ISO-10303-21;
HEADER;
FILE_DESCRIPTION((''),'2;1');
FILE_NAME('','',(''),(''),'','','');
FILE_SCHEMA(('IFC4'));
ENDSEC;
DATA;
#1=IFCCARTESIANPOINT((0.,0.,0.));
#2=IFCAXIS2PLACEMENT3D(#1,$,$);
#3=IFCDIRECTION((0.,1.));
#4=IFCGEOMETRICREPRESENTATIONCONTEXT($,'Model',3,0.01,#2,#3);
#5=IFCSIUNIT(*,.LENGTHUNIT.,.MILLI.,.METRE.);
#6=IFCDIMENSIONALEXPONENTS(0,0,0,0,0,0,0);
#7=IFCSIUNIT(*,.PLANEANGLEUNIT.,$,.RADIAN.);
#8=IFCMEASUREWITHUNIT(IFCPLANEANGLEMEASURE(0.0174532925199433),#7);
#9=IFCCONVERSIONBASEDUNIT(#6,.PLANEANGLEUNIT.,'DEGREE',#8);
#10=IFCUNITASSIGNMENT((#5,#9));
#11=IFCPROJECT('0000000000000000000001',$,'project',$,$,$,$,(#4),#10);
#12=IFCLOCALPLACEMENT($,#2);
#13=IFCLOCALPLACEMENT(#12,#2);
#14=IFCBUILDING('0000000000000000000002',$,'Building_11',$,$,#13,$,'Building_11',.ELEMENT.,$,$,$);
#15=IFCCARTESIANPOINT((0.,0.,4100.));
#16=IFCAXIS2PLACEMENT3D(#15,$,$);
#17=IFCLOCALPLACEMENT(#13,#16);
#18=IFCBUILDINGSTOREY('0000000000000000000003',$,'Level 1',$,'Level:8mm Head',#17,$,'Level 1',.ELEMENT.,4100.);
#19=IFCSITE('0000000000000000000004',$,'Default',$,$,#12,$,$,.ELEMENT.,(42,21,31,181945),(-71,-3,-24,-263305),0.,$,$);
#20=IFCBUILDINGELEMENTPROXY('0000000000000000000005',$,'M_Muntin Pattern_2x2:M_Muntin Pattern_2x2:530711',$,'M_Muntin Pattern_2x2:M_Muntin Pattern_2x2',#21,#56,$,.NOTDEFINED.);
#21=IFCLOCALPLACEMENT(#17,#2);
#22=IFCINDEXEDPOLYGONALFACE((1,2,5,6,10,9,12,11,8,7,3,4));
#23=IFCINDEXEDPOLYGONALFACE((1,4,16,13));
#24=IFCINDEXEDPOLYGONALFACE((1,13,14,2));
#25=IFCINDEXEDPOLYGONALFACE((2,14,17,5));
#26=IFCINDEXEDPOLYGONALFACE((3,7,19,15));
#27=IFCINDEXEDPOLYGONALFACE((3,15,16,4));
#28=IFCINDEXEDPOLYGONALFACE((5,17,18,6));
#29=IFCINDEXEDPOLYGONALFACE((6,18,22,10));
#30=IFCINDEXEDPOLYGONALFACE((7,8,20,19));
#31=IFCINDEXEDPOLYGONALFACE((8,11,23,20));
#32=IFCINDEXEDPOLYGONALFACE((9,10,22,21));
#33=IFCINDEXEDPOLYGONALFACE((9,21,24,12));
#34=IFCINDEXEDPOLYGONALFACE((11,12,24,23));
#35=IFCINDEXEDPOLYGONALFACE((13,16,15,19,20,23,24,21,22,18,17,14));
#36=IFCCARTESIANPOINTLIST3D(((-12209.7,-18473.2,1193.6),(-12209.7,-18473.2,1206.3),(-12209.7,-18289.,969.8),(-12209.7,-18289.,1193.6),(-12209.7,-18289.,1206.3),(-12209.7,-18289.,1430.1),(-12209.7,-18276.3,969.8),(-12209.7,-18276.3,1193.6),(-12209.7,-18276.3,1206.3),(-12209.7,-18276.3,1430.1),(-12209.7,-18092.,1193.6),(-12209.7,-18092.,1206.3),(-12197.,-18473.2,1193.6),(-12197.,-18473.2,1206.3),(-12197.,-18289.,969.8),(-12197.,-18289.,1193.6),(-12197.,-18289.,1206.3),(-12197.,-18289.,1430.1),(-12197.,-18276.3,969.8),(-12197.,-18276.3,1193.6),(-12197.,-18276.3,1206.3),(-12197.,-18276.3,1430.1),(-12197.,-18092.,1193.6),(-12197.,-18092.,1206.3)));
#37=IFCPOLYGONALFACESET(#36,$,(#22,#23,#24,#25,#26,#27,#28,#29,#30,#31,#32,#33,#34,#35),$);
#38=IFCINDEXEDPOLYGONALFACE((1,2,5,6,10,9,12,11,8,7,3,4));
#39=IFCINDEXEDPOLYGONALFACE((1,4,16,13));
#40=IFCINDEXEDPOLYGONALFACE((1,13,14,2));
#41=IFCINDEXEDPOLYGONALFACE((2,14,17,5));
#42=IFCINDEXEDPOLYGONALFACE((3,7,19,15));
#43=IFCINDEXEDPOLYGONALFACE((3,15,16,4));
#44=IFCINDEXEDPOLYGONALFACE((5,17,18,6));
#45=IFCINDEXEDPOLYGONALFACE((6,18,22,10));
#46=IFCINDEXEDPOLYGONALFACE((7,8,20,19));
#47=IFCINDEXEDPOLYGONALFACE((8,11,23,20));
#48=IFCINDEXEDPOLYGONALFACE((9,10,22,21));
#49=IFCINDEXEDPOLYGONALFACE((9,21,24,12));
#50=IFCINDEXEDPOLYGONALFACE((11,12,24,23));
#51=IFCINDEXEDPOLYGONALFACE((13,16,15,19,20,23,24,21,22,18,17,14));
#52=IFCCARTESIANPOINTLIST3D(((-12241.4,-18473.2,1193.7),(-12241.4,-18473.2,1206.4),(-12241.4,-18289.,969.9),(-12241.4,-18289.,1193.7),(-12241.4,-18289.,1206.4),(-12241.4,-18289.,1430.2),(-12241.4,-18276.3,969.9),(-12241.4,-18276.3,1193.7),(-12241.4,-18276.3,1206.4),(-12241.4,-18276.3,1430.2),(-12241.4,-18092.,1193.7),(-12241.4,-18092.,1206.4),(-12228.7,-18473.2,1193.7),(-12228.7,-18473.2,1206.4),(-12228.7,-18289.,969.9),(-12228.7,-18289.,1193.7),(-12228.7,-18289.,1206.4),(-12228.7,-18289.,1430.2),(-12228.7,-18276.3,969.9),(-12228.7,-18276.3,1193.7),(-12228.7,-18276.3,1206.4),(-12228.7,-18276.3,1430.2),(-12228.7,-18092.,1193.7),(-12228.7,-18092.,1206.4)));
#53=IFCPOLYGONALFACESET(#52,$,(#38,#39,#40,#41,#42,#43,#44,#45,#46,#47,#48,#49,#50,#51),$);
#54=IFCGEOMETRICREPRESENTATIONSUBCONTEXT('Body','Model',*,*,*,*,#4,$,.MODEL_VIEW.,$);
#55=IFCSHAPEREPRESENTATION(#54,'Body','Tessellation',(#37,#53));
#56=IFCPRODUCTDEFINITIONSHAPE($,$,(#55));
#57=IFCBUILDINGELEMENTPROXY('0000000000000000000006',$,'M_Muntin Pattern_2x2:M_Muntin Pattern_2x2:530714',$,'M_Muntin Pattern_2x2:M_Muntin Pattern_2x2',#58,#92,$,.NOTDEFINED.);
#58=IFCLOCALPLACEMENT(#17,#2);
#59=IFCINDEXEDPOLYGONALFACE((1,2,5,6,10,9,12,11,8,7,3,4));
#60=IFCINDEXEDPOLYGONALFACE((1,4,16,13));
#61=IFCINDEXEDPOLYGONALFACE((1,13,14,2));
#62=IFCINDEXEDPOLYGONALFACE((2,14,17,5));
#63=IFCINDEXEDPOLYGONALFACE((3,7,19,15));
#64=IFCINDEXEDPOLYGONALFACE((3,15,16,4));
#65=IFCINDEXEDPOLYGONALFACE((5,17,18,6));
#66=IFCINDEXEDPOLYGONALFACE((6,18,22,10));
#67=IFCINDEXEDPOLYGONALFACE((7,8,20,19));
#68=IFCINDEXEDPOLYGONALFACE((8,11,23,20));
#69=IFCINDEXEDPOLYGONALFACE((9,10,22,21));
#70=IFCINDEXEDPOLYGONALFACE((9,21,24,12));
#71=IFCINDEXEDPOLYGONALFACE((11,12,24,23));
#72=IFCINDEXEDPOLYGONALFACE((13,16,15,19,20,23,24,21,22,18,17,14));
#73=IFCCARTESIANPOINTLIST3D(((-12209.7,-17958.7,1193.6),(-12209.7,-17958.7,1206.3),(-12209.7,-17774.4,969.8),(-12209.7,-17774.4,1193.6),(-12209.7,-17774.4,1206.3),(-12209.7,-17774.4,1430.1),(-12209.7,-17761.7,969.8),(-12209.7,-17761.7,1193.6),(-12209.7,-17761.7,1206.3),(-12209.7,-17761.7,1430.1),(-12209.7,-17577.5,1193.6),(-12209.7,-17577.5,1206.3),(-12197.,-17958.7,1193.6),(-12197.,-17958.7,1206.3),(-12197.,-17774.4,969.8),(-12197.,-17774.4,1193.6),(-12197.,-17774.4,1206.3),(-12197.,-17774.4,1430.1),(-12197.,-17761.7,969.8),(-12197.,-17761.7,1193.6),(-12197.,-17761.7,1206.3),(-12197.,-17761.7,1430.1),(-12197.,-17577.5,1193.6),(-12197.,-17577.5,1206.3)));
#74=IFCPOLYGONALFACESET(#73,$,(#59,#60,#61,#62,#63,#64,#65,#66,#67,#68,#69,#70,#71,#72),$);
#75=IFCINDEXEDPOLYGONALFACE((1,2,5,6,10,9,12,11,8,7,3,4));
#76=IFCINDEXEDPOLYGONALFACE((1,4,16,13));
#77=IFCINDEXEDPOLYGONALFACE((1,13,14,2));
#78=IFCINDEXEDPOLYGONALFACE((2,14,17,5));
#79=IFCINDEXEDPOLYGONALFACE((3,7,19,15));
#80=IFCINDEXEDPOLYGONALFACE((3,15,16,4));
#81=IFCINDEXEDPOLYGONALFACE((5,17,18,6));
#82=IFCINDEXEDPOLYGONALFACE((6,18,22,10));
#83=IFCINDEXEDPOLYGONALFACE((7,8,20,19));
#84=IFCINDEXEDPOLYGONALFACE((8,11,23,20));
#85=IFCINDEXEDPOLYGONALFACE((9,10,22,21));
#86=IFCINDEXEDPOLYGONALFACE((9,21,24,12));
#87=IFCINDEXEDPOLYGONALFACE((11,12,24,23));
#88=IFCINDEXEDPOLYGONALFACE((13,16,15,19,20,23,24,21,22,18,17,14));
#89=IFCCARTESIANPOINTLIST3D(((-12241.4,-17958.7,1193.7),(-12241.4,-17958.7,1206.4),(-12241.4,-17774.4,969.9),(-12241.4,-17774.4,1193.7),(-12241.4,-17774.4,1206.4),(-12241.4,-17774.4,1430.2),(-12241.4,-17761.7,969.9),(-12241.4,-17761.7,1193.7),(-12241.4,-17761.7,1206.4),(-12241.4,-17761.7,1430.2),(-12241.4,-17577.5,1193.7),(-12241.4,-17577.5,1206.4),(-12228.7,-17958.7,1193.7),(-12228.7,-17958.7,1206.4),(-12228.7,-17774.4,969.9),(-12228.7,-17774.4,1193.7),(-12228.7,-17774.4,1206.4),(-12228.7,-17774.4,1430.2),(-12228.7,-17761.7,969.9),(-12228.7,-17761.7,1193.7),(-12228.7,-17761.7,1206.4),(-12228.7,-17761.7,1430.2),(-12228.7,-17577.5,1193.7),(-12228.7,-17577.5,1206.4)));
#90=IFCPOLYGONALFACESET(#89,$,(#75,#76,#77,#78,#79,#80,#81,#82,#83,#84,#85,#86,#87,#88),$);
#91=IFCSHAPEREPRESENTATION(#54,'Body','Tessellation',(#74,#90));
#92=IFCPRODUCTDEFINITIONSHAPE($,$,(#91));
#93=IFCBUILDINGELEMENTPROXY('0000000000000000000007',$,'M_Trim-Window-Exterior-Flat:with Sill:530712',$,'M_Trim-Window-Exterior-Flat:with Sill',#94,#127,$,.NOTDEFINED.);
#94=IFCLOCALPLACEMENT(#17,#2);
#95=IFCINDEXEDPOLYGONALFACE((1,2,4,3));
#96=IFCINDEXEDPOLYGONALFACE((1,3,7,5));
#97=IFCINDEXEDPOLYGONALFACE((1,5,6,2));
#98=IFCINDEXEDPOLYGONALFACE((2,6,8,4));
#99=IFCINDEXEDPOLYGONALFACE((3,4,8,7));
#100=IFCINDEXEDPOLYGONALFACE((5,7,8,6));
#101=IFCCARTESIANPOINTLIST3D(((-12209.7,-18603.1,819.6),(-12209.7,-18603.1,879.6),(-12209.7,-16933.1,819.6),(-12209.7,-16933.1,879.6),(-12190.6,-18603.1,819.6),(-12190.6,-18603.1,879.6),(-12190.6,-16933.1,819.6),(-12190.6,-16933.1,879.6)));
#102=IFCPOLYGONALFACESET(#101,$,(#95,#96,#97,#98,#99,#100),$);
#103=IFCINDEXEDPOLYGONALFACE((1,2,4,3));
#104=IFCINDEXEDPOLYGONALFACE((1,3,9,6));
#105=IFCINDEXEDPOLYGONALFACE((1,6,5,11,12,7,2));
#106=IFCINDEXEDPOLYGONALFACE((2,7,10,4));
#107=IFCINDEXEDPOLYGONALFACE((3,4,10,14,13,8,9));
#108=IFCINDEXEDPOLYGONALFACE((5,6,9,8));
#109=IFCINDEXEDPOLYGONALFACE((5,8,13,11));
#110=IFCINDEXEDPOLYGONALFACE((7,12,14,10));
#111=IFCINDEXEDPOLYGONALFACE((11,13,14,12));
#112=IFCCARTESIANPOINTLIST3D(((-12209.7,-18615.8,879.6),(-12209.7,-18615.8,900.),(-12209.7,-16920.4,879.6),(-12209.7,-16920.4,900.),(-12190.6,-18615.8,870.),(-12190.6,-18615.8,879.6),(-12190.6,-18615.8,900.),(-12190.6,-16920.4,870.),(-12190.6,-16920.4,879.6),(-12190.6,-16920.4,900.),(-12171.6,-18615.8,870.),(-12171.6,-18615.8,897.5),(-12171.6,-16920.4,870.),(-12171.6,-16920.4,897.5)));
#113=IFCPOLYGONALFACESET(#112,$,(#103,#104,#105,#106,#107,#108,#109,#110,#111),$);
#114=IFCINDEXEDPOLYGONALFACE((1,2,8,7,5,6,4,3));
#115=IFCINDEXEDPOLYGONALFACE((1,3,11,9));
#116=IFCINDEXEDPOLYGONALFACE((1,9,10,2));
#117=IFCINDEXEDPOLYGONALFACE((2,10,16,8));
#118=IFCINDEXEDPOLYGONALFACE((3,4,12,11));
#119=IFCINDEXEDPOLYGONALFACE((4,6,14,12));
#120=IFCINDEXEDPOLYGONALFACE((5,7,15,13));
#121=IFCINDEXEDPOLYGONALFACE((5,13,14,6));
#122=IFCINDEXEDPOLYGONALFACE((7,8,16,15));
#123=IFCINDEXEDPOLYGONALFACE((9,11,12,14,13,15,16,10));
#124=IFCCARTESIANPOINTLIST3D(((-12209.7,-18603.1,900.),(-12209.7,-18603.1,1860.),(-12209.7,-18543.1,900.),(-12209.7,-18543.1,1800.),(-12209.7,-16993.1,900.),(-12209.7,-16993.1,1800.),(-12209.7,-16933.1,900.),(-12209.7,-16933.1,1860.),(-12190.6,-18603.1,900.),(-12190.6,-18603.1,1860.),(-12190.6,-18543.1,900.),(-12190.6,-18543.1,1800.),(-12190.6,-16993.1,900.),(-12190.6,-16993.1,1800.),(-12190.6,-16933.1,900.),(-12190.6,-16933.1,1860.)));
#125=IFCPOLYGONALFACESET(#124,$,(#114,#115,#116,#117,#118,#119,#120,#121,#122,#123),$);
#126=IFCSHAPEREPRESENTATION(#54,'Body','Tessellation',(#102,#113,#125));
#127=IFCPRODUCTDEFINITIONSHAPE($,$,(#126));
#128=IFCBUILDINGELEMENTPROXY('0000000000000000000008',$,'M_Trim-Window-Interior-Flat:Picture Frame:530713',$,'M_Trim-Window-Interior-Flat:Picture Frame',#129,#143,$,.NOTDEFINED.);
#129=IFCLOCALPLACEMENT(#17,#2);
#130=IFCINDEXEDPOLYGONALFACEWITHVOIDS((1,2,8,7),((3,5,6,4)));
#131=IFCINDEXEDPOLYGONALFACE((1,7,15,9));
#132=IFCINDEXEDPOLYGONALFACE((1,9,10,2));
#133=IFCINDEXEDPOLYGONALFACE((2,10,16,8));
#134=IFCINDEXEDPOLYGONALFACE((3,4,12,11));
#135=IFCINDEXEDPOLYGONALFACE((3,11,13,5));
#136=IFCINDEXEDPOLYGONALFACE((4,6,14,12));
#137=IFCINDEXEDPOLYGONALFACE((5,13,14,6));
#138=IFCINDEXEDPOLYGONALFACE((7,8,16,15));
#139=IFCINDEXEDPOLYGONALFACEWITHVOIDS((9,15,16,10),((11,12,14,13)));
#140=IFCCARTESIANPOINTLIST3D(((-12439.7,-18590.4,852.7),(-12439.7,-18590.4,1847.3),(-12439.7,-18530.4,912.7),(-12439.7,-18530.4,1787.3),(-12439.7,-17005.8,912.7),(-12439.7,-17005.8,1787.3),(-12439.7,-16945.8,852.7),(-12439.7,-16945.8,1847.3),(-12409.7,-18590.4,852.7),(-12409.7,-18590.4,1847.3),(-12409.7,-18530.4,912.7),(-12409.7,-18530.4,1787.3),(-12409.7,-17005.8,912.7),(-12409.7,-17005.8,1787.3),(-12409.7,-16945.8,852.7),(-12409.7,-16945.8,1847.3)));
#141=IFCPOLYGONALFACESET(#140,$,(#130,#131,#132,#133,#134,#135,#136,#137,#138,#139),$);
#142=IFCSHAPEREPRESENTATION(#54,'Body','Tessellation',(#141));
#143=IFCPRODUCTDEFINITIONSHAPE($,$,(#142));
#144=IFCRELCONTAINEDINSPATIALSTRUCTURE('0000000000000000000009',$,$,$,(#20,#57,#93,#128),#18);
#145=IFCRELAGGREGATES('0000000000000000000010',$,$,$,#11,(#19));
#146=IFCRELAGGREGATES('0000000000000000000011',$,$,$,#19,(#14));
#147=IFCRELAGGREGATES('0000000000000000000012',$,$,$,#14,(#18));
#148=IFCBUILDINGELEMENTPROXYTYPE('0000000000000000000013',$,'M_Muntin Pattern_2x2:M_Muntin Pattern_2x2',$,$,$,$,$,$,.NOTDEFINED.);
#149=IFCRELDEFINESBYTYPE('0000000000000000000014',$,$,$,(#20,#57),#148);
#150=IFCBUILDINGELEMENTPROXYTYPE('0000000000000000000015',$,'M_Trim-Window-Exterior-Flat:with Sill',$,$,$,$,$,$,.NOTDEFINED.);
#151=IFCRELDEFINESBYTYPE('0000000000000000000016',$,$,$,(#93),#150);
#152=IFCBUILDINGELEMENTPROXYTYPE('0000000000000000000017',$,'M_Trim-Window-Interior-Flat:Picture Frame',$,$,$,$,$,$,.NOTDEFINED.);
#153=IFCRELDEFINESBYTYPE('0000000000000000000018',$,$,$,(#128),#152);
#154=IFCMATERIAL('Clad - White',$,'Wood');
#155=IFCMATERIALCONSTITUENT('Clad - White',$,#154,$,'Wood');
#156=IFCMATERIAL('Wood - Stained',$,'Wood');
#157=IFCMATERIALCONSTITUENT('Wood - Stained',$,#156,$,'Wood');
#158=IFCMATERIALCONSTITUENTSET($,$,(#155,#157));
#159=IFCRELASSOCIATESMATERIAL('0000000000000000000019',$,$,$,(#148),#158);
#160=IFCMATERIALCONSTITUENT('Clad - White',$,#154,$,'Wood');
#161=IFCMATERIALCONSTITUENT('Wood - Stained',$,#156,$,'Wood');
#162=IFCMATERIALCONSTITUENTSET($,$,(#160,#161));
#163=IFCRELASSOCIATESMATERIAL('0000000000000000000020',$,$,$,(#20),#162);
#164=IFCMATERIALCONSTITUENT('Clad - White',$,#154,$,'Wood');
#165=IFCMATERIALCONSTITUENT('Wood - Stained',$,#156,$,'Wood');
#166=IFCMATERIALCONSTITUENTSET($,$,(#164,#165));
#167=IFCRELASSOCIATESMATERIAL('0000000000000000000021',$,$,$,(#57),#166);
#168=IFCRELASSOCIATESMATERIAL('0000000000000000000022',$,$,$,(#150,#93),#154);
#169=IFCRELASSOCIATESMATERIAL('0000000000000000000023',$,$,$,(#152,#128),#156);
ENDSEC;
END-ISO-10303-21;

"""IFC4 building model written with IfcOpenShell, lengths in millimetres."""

from ifc_helpers import new_model, entity, si_unit, converted_unit, direction, frame, origin, place, context, subcontext, project, spatial, indexed_curve, outline, extrude, source, transform, mapped, material, constituent, constituent_set, type_object, type_shapes, element, save


model = new_model("IFC4")

# Units and contexts
model_context = context("Model", 3, precision=0.01, world=origin(), true_north=direction((0.0, 1.0)))
body_context = subcontext(model_context, "Body", "Model", "MODEL_VIEW")
ifc_project = project(units=[si_unit("LENGTHUNIT", "METRE", prefix="MILLI"), converted_unit("PLANEANGLEUNIT", "DEGREE", entity("IfcPlaneAngleMeasure", 0.0174532925199433), si_unit("PLANEANGLEUNIT", "RADIAN"), dimensions=[0, 0, 0, 0, 0, 0, 0])], contexts=[model_context])

# Site, building, storey
site_placement = place(None, origin())
site = spatial("IfcSite", under=ifc_project, at=site_placement, Name="Default", CompositionType="ELEMENT", RefLatitude=(42, 21, 31, 181945), RefLongitude=(-71, -3, -24, -263305), RefElevation=0.0)
building_placement = place(site_placement, origin())
building = spatial("IfcBuilding", under=site, at=building_placement, Name="Building_11", LongName="Building_11", CompositionType="ELEMENT")
storey_placement = place(building_placement, frame((0.0, 0.0, 4100.0)))
storey = spatial("IfcBuildingStorey", under=building, at=storey_placement, Name="Level 1", ObjectType="Level:8mm Head", LongName="Level 1", CompositionType="ELEMENT", Elevation=4100.0)

# Building element proxies
ifc_material_1 = material(Name="Clad - White", Category="Wood")
ifc_material_2 = material(Name="Wood - Stained", Category="Wood")
ifc_constituent_1 = constituent(ifc_material_1, Name="Clad - White", Category="Wood")
ifc_constituent_2 = constituent(ifc_material_2, Name="Wood - Stained", Category="Wood")
ifc_constituent_set_1 = constituent_set(constituents=[ifc_constituent_1, ifc_constituent_2])
ifc_constituent_3 = constituent(ifc_material_1, Name="Clad - White", Category="Wood")
ifc_constituent_4 = constituent(ifc_material_2, Name="Wood - Stained", Category="Wood")
ifc_constituent_set_2 = constituent_set(constituents=[ifc_constituent_3, ifc_constituent_4])
building_element_proxy_type_1 = type_object("IfcBuildingElementProxyType", Name="M_Muntin Pattern_2x2:M_Muntin Pattern_2x2", PredefinedType="NOTDEFINED", material=ifc_constituent_set_2)
shared_shape_1 = source(origin(), body_context, "Body", "SweptSolid", [
    extrude(outline(indexed_curve([(6.4, -6.4), (230.1, -6.4), (230.1, 6.3), (6.4, 6.3), (6.4, 190.6), (-6.3, 190.6), (-6.3, 6.3), (-230.2, 6.3), (-230.2, -6.4), (-6.3, -6.4), (-6.3, -190.6), (6.4, -190.6), (6.4, -6.4)], self_intersect=False)), frame((0.0, -22.2, 230.1), z_axis=(0.0, 1.0, 0.0), x_axis=(0.0, 0.0, 1.0)), (0.0, 0.0, 1.0), 12.7),
    extrude(outline(indexed_curve([(6.4, -6.4), (230.2, -6.4), (230.2, 6.3), (6.4, 6.3), (6.4, 190.6), (-6.3, 190.6), (-6.3, 6.3), (-230.2, 6.3), (-230.2, -6.4), (-6.3, -6.4), (-6.3, -190.6), (6.4, -190.6), (6.4, -6.4)], self_intersect=False)), frame((0.0, 9.5, 230.2), z_axis=(0.0, 1.0, 0.0), x_axis=(0.0, 0.0, 1.0)), (0.0, 0.0, 1.0), 12.7),
])
type_shapes(building_element_proxy_type_1, [shared_shape_1])
proxy_1_placement = place(storey_placement, frame((-12219.2, -18282.6, 969.9), z_axis=(0.0, 0.0, 1.0), x_axis=(0.0, 1.0, 0.0)))
element("IfcBuildingElementProxy", 1, at=proxy_1_placement, inside=storey, type_object=building_element_proxy_type_1, material=ifc_constituent_set_1, Name="M_Muntin Pattern_2x2:M_Muntin Pattern_2x2:530711", ObjectType="M_Muntin Pattern_2x2:M_Muntin Pattern_2x2", PredefinedType="NOTDEFINED", context=body_context, shape_type="MappedRepresentation", body=[
    mapped(shared_shape_1, transform((0.0, 0.0, 0.0), scale=1.0)),
])
ifc_constituent_5 = constituent(ifc_material_1, Name="Clad - White", Category="Wood")
ifc_constituent_6 = constituent(ifc_material_2, Name="Wood - Stained", Category="Wood")
ifc_constituent_set_3 = constituent_set(constituents=[ifc_constituent_5, ifc_constituent_6])
proxy_2_placement = place(storey_placement, frame((-12219.2, -17768.1, 969.9), z_axis=(0.0, 0.0, 1.0), x_axis=(0.0, 1.0, 0.0)))
element("IfcBuildingElementProxy", 2, at=proxy_2_placement, inside=storey, type_object=building_element_proxy_type_1, material=ifc_constituent_set_3, Name="M_Muntin Pattern_2x2:M_Muntin Pattern_2x2:530714", ObjectType="M_Muntin Pattern_2x2:M_Muntin Pattern_2x2", PredefinedType="NOTDEFINED", context=body_context, shape_type="MappedRepresentation", body=[
    mapped(shared_shape_1, transform((0.0, 0.0, 0.0), scale=1.0)),
])
building_element_proxy_type_2 = type_object("IfcBuildingElementProxyType", Name="M_Trim-Window-Exterior-Flat:with Sill", PredefinedType="NOTDEFINED", material=ifc_material_1)
shared_shape_2 = source(origin(), body_context, "Body", "SweptSolid", [
    extrude(outline(indexed_curve([(-835.0, -30.0), (835.0, -30.0), (835.0, 30.0), (-835.0, 30.0), (-835.0, -30.0)], self_intersect=False)), frame((0.0, -950.4, 0.0), z_axis=(0.0, 0.0, 1.0), x_axis=(-1.0, 0.0, 0.0)), (0.0, 0.0, 1.0), 19.1),
    extrude(outline(indexed_curve([(-19.0, -15.2), (0.0, -15.2), (0.0, -5.7), (19.0, -5.7), (19.0, 14.8), (0.0, 14.8), (-19.0, 12.3), (-19.0, -15.2)], self_intersect=False)), frame((-847.7, -914.8, 19.0), z_axis=(1.0, 0.0, 0.0), x_axis=(0.0, 0.0, -1.0)), (0.0, 0.0, 1.0), 1695.4),
    extrude(outline(indexed_curve([(-495.0, -835.0), (465.0, -835.0), (465.0, -775.0), (-435.0, -775.0), (-435.0, 775.0), (465.0, 775.0), (465.0, 835.0), (-495.0, 835.0), (-495.0, -835.0)], self_intersect=False)), frame((0.0, -435.0, 0.0), z_axis=(0.0, 0.0, 1.0), x_axis=(0.0, -1.0, 0.0)), (0.0, 0.0, 1.0), 19.1),
])
type_shapes(building_element_proxy_type_2, [shared_shape_2])
proxy_3_placement = place(storey_placement, frame((-12209.7, -17768.1, 1800.0), z_axis=(1.0, 0.0, 0.0), x_axis=(0.0, 1.0, 0.0)))
element("IfcBuildingElementProxy", 3, at=proxy_3_placement, inside=storey, type_object=building_element_proxy_type_2, material=ifc_material_1, Name="M_Trim-Window-Exterior-Flat:with Sill:530712", ObjectType="M_Trim-Window-Exterior-Flat:with Sill", PredefinedType="NOTDEFINED", context=body_context, shape_type="MappedRepresentation", body=[
    mapped(shared_shape_2, transform((0.0, 0.0, 0.0), scale=1.0)),
])
building_element_proxy_type_3 = type_object("IfcBuildingElementProxyType", Name="M_Trim-Window-Interior-Flat:Picture Frame", PredefinedType="NOTDEFINED", material=ifc_material_2)
shared_shape_3 = source(origin(), body_context, "Body", "SweptSolid", [
    extrude(outline(indexed_curve([(-822.3, -497.3), (822.3, -497.3), (822.3, 497.3), (-822.3, 497.3), (-822.3, -497.3)], self_intersect=False), holes=[indexed_curve([(-762.3, -437.3), (-762.3, 437.3), (762.3, 437.3), (762.3, -437.3), (-762.3, -437.3)], self_intersect=False)]), frame((0.0, -450.0, 0.0), z_axis=(0.0, 0.0, 1.0), x_axis=(-1.0, 0.0, 0.0)), (0.0, 0.0, 1.0), 30.0),
])
type_shapes(building_element_proxy_type_3, [shared_shape_3])
proxy_4_placement = place(storey_placement, frame((-12409.7, -17768.1, 1800.0), z_axis=(-1.0, 0.0, 0.0), x_axis=(0.0, -1.0, 0.0)))
element("IfcBuildingElementProxy", 4, at=proxy_4_placement, inside=storey, type_object=building_element_proxy_type_3, material=ifc_material_2, Name="M_Trim-Window-Interior-Flat:Picture Frame:530713", ObjectType="M_Trim-Window-Interior-Flat:Picture Frame", PredefinedType="NOTDEFINED", context=body_context, shape_type="MappedRepresentation", body=[
    mapped(shared_shape_3, transform((0.0, 0.0, 0.0), scale=1.0)),
])

save(model, "model.ifc")
